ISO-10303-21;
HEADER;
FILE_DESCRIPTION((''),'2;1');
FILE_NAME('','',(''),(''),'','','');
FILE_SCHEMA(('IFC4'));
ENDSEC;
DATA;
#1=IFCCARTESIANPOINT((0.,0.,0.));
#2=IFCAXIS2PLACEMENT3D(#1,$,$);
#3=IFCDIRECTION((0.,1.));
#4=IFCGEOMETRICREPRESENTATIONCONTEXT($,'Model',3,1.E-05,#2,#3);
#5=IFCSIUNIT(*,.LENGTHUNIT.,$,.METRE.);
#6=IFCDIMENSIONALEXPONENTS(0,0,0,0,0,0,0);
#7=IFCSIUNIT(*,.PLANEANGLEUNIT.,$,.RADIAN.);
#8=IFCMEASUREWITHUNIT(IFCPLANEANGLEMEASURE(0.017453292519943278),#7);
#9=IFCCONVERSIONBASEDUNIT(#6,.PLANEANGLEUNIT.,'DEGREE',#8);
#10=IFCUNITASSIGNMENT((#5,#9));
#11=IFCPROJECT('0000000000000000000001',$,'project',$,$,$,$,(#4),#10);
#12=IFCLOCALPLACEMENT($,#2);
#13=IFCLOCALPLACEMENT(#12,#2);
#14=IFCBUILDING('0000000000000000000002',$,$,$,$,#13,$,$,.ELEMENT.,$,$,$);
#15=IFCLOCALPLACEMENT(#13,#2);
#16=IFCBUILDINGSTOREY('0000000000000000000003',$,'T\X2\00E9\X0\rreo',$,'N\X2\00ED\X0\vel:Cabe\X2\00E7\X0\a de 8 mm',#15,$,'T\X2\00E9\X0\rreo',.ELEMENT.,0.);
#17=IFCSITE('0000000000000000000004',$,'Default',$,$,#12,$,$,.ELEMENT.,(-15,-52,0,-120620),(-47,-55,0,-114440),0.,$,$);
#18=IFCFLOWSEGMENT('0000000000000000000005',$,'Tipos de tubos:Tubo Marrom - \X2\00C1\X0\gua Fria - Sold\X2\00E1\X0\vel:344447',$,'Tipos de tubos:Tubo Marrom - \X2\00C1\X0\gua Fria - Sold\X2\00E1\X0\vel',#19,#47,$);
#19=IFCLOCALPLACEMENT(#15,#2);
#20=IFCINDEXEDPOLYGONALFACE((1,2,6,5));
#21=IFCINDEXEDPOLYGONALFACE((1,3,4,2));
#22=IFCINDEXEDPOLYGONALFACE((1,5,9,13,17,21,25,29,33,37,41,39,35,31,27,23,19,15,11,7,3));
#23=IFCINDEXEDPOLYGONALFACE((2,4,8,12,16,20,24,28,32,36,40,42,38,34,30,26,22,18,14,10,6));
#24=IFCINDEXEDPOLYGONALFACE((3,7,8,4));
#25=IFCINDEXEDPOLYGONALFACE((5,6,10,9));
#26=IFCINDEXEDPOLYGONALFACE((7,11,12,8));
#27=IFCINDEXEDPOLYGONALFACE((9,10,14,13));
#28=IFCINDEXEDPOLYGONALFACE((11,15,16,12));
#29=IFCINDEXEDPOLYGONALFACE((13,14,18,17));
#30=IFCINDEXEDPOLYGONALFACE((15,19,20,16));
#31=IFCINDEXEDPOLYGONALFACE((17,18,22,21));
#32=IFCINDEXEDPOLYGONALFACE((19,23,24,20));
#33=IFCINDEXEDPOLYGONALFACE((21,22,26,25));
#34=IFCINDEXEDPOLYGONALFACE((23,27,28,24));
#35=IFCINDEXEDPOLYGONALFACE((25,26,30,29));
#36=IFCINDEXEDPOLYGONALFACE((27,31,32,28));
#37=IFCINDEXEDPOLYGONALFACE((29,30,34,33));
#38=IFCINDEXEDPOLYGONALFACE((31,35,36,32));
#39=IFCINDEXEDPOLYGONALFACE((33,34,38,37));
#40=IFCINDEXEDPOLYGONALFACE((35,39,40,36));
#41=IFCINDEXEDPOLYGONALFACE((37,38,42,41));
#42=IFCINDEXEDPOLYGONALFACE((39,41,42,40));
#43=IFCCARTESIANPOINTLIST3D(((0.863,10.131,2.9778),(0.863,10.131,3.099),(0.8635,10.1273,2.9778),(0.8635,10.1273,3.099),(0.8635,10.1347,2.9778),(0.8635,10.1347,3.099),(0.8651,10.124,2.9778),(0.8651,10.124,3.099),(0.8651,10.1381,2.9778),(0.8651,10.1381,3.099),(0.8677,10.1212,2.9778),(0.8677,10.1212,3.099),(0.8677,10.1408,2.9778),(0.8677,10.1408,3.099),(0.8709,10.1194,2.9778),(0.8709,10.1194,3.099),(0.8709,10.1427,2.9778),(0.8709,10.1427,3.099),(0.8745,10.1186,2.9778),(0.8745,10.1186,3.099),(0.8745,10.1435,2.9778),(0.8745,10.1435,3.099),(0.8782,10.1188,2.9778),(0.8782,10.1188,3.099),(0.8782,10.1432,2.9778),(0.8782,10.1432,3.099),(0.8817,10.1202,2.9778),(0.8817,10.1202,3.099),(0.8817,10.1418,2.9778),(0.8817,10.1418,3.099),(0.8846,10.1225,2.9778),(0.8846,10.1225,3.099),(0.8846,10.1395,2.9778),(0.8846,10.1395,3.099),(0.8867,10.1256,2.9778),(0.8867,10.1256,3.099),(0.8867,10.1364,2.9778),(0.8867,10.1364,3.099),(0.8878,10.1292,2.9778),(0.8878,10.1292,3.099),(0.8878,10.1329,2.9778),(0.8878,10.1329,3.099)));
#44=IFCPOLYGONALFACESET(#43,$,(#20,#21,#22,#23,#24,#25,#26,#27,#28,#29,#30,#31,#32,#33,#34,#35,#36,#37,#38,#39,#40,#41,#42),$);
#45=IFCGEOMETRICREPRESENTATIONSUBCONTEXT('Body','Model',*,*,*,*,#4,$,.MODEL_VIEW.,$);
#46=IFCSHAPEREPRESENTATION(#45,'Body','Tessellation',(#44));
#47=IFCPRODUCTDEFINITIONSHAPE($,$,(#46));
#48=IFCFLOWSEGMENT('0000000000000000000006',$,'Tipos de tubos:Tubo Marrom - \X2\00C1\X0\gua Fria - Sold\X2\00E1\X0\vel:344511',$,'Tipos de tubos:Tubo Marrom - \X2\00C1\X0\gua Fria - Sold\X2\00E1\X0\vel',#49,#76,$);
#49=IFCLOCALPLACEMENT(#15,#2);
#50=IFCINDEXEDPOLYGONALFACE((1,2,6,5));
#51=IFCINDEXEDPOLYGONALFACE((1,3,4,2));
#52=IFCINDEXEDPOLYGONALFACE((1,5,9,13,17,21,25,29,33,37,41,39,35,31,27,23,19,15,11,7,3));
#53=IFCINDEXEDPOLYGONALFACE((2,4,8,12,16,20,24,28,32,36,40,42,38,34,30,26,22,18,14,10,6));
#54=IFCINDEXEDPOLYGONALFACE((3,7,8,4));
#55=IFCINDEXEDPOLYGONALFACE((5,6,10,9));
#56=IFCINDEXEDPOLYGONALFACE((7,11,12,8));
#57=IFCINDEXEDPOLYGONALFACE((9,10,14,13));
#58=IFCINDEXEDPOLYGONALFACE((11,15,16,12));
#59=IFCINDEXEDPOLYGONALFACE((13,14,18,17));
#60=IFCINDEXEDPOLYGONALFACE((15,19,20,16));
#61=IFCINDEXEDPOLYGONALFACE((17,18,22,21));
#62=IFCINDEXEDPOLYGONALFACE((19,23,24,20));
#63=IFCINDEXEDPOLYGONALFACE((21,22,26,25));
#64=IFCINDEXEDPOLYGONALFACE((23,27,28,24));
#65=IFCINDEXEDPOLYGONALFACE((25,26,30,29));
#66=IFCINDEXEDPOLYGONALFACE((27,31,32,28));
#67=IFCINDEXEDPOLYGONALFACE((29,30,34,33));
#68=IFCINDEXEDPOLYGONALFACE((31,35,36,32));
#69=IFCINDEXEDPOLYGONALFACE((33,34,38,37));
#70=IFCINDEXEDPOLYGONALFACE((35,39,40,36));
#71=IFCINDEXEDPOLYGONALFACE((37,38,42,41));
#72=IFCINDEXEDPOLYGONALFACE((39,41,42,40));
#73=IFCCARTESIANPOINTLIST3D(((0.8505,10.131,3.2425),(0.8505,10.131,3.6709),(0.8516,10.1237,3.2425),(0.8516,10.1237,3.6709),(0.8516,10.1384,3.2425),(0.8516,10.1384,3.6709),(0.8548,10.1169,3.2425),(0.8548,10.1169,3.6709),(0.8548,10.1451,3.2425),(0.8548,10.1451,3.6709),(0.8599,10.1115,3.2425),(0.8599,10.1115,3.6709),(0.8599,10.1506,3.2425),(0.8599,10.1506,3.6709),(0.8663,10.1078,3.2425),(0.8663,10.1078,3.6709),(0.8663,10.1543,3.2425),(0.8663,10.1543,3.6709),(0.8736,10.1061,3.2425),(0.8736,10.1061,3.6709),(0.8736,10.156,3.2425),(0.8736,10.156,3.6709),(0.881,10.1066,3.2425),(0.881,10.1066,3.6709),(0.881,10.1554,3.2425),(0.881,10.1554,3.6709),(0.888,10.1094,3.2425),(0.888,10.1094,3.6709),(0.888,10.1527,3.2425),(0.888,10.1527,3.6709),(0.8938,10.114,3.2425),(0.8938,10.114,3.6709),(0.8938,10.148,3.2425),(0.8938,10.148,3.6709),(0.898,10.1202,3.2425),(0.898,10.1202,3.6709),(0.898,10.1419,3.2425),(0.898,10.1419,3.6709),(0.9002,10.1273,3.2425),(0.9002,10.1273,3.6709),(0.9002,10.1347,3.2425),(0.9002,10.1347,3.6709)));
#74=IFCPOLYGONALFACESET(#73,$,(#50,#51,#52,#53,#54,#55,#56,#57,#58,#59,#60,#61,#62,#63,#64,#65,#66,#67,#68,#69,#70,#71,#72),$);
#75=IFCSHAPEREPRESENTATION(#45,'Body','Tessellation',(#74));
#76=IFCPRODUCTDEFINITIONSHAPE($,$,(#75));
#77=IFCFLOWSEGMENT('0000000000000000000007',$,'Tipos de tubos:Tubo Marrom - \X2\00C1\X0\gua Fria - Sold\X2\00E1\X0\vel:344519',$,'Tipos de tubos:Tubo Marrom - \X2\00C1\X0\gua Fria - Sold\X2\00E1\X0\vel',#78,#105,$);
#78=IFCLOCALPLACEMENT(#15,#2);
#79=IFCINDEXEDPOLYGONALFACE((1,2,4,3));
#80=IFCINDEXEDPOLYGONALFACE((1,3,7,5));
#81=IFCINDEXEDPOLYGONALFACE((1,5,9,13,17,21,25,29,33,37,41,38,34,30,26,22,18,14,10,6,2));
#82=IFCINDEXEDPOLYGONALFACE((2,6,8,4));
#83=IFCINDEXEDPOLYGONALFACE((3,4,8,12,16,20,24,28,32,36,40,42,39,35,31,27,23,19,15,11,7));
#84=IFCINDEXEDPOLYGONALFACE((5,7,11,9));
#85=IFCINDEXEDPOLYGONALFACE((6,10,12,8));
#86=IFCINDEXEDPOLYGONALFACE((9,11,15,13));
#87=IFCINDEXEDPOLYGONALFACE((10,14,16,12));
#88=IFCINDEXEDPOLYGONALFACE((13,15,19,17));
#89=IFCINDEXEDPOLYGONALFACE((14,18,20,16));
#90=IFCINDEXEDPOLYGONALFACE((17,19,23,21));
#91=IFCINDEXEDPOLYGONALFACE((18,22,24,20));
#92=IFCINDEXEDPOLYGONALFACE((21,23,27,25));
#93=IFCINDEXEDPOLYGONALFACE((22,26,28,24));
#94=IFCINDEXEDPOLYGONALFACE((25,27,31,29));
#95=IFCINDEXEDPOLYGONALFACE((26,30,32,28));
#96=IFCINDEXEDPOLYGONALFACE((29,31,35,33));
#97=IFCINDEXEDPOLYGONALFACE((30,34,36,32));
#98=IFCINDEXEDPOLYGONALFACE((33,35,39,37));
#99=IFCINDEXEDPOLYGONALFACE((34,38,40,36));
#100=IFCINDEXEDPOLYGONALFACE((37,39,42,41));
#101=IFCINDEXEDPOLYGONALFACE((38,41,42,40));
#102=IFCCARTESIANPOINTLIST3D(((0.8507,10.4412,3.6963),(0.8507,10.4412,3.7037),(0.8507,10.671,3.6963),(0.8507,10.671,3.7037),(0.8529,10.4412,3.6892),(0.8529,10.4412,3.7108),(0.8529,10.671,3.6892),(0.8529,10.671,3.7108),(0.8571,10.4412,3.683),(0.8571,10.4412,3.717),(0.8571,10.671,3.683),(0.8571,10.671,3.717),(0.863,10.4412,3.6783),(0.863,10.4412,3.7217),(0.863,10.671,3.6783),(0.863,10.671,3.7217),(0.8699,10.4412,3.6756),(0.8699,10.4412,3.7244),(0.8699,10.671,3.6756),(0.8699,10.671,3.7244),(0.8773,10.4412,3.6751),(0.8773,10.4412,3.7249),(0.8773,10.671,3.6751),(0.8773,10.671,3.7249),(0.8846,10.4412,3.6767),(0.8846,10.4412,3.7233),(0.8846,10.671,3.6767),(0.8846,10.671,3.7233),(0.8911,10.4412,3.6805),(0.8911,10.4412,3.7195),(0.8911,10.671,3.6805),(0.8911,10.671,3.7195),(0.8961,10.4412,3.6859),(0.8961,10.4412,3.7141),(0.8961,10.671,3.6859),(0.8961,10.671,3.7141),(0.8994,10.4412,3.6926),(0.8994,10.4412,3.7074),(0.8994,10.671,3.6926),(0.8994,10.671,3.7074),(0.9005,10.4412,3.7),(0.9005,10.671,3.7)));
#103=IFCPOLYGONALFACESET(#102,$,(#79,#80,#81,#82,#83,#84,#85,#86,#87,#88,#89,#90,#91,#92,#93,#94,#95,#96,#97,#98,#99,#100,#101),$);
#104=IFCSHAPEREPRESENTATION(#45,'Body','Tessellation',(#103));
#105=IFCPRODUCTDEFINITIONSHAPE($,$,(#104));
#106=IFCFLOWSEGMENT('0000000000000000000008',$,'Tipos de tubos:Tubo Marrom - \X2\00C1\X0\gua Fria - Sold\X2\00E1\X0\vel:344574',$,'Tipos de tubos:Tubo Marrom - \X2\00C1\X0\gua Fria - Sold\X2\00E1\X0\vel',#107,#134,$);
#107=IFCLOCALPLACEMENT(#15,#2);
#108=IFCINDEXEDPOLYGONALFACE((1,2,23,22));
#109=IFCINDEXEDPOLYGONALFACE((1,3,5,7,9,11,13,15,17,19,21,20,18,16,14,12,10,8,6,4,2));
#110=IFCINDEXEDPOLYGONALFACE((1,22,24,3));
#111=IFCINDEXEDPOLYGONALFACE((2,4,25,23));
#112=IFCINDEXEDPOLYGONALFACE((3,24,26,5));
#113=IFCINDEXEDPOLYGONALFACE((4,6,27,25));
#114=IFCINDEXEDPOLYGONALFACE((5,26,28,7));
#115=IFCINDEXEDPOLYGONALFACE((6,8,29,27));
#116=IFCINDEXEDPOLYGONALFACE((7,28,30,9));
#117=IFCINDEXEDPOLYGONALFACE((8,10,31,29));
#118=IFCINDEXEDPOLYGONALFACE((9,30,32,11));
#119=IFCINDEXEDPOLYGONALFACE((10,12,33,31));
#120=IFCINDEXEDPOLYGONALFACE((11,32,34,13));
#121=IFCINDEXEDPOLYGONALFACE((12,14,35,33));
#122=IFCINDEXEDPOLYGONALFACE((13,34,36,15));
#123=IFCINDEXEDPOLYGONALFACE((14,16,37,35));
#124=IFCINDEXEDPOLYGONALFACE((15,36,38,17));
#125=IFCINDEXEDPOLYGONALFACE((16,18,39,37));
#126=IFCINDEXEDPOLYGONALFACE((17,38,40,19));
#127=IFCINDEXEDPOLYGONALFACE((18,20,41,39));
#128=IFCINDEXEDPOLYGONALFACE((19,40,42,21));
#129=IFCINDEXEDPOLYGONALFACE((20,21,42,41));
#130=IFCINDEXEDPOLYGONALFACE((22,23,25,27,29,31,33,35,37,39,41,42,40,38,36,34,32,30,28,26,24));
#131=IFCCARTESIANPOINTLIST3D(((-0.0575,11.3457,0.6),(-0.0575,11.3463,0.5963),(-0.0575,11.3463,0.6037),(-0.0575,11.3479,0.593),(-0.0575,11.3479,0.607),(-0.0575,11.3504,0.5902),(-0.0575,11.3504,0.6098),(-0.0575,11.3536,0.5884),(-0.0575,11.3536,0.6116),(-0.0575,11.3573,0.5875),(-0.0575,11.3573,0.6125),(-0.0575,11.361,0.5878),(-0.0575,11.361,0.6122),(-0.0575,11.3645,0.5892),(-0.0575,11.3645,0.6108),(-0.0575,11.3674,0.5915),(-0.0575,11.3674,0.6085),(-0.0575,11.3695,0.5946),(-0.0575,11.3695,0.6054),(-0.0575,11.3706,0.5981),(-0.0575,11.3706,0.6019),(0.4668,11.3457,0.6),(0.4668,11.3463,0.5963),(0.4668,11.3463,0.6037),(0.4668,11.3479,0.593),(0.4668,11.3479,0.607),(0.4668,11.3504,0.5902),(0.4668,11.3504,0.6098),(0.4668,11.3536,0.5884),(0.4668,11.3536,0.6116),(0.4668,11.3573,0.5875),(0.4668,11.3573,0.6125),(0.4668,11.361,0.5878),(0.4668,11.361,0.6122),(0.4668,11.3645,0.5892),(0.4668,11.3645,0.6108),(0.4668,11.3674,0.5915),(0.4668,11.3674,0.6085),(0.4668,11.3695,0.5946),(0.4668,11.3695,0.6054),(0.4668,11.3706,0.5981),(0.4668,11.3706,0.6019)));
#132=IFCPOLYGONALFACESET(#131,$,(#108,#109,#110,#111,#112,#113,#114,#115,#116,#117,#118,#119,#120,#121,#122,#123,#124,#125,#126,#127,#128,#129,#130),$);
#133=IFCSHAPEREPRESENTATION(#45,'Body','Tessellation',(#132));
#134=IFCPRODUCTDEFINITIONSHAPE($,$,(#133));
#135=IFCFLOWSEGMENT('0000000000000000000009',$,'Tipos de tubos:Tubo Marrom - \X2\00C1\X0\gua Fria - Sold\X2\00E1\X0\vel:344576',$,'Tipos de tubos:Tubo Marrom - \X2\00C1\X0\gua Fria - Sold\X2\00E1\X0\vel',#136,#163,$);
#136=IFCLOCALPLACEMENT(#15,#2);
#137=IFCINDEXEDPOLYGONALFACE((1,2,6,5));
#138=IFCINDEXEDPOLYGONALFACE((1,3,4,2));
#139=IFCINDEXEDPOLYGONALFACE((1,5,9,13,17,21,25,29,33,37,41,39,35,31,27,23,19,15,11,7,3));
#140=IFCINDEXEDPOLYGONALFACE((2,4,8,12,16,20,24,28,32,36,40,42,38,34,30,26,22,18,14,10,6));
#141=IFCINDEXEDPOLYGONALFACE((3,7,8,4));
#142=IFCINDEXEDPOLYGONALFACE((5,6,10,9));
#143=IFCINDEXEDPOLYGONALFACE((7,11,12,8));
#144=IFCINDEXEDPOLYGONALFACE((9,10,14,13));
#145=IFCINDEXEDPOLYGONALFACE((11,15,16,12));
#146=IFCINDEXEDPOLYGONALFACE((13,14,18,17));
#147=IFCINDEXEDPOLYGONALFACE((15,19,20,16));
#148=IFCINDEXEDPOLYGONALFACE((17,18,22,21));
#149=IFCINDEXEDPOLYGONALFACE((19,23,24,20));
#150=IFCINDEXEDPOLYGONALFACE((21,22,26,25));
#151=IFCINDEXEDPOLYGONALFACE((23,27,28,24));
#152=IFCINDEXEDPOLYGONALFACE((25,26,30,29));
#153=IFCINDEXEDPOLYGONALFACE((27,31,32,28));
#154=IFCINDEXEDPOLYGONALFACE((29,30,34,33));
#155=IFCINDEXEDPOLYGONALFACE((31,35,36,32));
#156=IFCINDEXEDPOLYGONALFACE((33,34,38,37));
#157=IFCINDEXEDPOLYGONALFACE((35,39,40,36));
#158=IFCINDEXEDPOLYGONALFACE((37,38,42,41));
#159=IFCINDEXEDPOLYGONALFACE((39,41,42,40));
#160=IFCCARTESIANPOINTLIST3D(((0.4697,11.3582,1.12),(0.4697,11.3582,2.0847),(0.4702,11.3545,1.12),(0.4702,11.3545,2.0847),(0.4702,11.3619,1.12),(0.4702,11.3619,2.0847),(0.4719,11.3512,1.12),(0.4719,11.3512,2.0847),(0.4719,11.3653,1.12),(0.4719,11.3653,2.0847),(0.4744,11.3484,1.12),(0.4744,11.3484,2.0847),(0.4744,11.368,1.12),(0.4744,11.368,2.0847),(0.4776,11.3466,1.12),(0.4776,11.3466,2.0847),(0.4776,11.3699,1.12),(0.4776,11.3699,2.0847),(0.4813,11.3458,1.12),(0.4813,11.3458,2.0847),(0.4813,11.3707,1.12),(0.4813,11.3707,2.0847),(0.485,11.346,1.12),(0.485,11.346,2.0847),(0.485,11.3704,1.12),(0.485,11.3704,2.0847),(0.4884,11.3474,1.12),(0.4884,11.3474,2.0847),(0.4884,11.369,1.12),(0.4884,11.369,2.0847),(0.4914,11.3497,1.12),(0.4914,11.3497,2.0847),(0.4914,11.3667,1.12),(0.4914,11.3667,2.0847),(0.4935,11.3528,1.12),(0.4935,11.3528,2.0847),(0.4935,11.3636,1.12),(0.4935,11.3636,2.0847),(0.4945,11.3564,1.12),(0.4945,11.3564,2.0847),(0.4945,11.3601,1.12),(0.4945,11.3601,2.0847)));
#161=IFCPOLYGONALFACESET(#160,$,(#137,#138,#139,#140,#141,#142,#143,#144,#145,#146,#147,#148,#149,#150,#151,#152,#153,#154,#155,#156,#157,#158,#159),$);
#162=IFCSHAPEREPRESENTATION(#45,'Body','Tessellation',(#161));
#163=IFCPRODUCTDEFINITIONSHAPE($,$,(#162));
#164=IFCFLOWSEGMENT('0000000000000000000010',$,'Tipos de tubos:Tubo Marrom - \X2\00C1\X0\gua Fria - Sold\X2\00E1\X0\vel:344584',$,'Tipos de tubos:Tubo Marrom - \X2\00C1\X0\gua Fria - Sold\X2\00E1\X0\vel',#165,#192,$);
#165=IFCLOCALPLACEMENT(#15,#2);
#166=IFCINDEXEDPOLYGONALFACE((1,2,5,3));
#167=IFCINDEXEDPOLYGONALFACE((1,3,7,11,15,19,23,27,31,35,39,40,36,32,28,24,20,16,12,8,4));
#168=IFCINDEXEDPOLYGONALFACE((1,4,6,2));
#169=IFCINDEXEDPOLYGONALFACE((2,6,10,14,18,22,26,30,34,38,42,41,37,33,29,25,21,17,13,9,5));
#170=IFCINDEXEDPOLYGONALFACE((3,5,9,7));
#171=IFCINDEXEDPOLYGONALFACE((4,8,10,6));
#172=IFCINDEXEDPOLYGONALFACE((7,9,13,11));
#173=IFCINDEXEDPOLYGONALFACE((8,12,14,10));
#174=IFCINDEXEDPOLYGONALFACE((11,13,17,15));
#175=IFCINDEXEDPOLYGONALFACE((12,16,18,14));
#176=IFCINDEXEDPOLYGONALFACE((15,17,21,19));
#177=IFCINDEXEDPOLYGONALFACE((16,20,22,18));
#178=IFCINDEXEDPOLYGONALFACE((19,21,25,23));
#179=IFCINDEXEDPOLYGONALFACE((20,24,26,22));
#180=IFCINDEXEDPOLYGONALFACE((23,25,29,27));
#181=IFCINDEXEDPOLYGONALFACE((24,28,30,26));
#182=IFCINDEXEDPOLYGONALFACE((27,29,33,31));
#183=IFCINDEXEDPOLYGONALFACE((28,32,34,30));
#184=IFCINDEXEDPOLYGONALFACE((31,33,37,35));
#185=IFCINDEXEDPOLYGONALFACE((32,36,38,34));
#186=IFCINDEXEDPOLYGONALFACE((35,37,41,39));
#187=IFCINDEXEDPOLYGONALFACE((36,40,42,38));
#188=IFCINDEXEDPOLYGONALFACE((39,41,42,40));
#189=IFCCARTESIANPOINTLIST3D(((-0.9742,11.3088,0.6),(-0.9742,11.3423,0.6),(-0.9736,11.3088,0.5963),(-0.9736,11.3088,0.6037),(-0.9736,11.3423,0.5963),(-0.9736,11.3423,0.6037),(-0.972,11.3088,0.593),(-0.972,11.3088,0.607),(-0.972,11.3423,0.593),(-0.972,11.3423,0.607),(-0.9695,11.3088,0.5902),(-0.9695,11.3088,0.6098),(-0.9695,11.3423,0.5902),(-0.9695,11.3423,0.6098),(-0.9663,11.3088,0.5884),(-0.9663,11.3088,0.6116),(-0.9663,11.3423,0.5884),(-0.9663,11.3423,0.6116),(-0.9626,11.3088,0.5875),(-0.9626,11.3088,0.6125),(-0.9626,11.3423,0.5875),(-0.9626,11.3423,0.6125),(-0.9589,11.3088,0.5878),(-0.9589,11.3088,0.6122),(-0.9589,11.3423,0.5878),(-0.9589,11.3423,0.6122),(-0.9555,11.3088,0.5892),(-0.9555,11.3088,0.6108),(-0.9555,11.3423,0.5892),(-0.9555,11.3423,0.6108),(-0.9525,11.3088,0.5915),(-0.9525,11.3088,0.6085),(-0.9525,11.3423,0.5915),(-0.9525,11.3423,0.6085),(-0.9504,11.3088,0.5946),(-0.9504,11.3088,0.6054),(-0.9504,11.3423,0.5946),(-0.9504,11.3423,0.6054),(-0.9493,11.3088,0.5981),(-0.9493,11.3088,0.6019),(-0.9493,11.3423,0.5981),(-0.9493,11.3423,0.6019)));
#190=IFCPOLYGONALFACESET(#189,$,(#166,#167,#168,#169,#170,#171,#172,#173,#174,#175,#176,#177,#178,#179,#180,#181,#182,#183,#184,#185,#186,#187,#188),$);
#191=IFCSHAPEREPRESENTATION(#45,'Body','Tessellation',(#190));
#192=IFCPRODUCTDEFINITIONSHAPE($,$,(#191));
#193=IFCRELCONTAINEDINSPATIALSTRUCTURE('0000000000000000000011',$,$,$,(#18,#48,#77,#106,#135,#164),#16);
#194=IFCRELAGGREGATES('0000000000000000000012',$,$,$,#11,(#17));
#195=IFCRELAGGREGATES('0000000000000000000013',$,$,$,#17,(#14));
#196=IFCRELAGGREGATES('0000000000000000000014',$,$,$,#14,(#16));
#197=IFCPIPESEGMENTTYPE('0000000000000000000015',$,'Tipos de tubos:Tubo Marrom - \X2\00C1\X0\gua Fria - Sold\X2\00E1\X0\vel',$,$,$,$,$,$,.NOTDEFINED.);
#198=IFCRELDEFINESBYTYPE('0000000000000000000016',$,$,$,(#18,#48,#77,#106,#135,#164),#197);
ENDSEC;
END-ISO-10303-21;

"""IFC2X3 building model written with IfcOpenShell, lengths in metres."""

from ifc_helpers import new_model, entity, si_unit, converted_unit, direction, frame, frame_2d, origin, origin_2d_with_axis, place, context, subcontext, project, spatial, circle, extrude, type_object, element, save


model = new_model("IFC2X3")

# Units and contexts
model_context = context("Model", 3, precision=1e-05, world=origin(), true_north=direction((0.0, 1.0)))
body_context = subcontext(model_context, "Body", "Model", "MODEL_VIEW")
ifc_project = project(units=[si_unit("LENGTHUNIT", "METRE"), converted_unit("PLANEANGLEUNIT", "DEGREE", entity("IfcPlaneAngleMeasure", 0.017453292519943278), si_unit("PLANEANGLEUNIT", "RADIAN"), dimensions=[0, 0, 0, 0, 0, 0, 0])], contexts=[model_context])

# Site, building, storey
site_placement = place(None, origin())
site = spatial("IfcSite", under=ifc_project, at=site_placement, Name="Default", CompositionType="ELEMENT", RefLatitude=(-15, -52, 0, -120620), RefLongitude=(-47, -55, 0, -114440), RefElevation=0.0)
building_placement = place(site_placement, origin())
building = spatial("IfcBuilding", under=site, at=building_placement, CompositionType="ELEMENT")
storey_placement = place(building_placement, origin())
storey = spatial("IfcBuildingStorey", under=building, at=storey_placement, Name="Térreo", ObjectType="Nível:Cabeça de 8 mm", LongName="Térreo", CompositionType="ELEMENT", Elevation=0.0)

# Flow segments
pipe_segment_type = type_object("IfcPipeSegmentType", Name="Tipos de tubos:Tubo Marrom - Água Fria - Soldável", PredefinedType="NOTDEFINED")
flow_segment_1_placement = place(storey_placement, origin())
element("IfcFlowSegment", 1, at=flow_segment_1_placement, inside=storey, type_object=pipe_segment_type, Name="Tipos de tubos:Tubo Marrom - Água Fria - Soldável:344447", ObjectType="Tipos de tubos:Tubo Marrom - Água Fria - Soldável", context=body_context, shape_type="SweptSolid", body=[
    extrude(circle(Radius=0.0125, at=frame_2d((0.0, 0.0), x_axis=(1.0, 0.0))), frame((0.8755, 10.131, 2.9778), z_axis=(0.0, 0.0, 1.0), x_axis=(-1.0, 0.0, 0.0)), (0.0, 0.0, 1.0), 0.1212),
])
flow_segment_2_placement = place(storey_placement, origin())
element("IfcFlowSegment", 2, at=flow_segment_2_placement, inside=storey, type_object=pipe_segment_type, Name="Tipos de tubos:Tubo Marrom - Água Fria - Soldável:344511", ObjectType="Tipos de tubos:Tubo Marrom - Água Fria - Soldável", context=body_context, shape_type="SweptSolid", body=[
    extrude(circle(Radius=0.025, at=frame_2d((0.0, 0.0), x_axis=(1.0, 0.0))), frame((0.8755, 10.131, 3.2425), z_axis=(0.0, 0.0, 1.0), x_axis=(-1.0, 0.0, 0.0)), (0.0, 0.0, 1.0), 0.4284),
])
flow_segment_3_placement = place(storey_placement, origin())
element("IfcFlowSegment", 3, at=flow_segment_3_placement, inside=storey, type_object=pipe_segment_type, Name="Tipos de tubos:Tubo Marrom - Água Fria - Soldável:344519", ObjectType="Tipos de tubos:Tubo Marrom - Água Fria - Soldável", context=body_context, shape_type="SweptSolid", body=[
    extrude(circle(Radius=0.025, at=origin_2d_with_axis()), frame((0.8755, 10.4412, 3.7), z_axis=(0.0, 1.0, 0.0), x_axis=(1.0, 0.0, 0.0)), (0.0, 0.0, 1.0), 0.2299),
])
flow_segment_4_placement = place(storey_placement, origin())
element("IfcFlowSegment", 4, at=flow_segment_4_placement, inside=storey, type_object=pipe_segment_type, Name="Tipos de tubos:Tubo Marrom - Água Fria - Soldável:344574", ObjectType="Tipos de tubos:Tubo Marrom - Água Fria - Soldável", context=body_context, shape_type="SweptSolid", body=[
    extrude(circle(Radius=0.0125, at=origin_2d_with_axis()), frame((-0.0575, 11.3582, 0.6), z_axis=(1.0, 0.0, 0.0), x_axis=(0.0, -1.0, 0.0)), (0.0, 0.0, 1.0), 0.5242),
])
flow_segment_5_placement = place(storey_placement, origin())
element("IfcFlowSegment", 5, at=flow_segment_5_placement, inside=storey, type_object=pipe_segment_type, Name="Tipos de tubos:Tubo Marrom - Água Fria - Soldável:344576", ObjectType="Tipos de tubos:Tubo Marrom - Água Fria - Soldável", context=body_context, shape_type="SweptSolid", body=[
    extrude(circle(Radius=0.0125, at=frame_2d((0.0, 0.0), x_axis=(1.0, 0.0))), frame((0.4822, 11.3582, 1.12), z_axis=(0.0, 0.0, 1.0), x_axis=(-1.0, 0.0, 0.0)), (0.0, 0.0, 1.0), 0.9647),
])
flow_segment_6_placement = place(storey_placement, origin())
element("IfcFlowSegment", 6, at=flow_segment_6_placement, inside=storey, type_object=pipe_segment_type, Name="Tipos de tubos:Tubo Marrom - Água Fria - Soldável:344584", ObjectType="Tipos de tubos:Tubo Marrom - Água Fria - Soldável", context=body_context, shape_type="SweptSolid", body=[
    extrude(circle(Radius=0.0125, at=frame_2d((0.0, 0.0), x_axis=(1.0, 0.0))), frame((-0.9617, 11.3088, 0.6), z_axis=(0.0, 1.0, 0.0), x_axis=(-1.0, 0.0, 0.0)), (0.0, 0.0, 1.0), 0.0335),
])

save(model, "model.ifc")
